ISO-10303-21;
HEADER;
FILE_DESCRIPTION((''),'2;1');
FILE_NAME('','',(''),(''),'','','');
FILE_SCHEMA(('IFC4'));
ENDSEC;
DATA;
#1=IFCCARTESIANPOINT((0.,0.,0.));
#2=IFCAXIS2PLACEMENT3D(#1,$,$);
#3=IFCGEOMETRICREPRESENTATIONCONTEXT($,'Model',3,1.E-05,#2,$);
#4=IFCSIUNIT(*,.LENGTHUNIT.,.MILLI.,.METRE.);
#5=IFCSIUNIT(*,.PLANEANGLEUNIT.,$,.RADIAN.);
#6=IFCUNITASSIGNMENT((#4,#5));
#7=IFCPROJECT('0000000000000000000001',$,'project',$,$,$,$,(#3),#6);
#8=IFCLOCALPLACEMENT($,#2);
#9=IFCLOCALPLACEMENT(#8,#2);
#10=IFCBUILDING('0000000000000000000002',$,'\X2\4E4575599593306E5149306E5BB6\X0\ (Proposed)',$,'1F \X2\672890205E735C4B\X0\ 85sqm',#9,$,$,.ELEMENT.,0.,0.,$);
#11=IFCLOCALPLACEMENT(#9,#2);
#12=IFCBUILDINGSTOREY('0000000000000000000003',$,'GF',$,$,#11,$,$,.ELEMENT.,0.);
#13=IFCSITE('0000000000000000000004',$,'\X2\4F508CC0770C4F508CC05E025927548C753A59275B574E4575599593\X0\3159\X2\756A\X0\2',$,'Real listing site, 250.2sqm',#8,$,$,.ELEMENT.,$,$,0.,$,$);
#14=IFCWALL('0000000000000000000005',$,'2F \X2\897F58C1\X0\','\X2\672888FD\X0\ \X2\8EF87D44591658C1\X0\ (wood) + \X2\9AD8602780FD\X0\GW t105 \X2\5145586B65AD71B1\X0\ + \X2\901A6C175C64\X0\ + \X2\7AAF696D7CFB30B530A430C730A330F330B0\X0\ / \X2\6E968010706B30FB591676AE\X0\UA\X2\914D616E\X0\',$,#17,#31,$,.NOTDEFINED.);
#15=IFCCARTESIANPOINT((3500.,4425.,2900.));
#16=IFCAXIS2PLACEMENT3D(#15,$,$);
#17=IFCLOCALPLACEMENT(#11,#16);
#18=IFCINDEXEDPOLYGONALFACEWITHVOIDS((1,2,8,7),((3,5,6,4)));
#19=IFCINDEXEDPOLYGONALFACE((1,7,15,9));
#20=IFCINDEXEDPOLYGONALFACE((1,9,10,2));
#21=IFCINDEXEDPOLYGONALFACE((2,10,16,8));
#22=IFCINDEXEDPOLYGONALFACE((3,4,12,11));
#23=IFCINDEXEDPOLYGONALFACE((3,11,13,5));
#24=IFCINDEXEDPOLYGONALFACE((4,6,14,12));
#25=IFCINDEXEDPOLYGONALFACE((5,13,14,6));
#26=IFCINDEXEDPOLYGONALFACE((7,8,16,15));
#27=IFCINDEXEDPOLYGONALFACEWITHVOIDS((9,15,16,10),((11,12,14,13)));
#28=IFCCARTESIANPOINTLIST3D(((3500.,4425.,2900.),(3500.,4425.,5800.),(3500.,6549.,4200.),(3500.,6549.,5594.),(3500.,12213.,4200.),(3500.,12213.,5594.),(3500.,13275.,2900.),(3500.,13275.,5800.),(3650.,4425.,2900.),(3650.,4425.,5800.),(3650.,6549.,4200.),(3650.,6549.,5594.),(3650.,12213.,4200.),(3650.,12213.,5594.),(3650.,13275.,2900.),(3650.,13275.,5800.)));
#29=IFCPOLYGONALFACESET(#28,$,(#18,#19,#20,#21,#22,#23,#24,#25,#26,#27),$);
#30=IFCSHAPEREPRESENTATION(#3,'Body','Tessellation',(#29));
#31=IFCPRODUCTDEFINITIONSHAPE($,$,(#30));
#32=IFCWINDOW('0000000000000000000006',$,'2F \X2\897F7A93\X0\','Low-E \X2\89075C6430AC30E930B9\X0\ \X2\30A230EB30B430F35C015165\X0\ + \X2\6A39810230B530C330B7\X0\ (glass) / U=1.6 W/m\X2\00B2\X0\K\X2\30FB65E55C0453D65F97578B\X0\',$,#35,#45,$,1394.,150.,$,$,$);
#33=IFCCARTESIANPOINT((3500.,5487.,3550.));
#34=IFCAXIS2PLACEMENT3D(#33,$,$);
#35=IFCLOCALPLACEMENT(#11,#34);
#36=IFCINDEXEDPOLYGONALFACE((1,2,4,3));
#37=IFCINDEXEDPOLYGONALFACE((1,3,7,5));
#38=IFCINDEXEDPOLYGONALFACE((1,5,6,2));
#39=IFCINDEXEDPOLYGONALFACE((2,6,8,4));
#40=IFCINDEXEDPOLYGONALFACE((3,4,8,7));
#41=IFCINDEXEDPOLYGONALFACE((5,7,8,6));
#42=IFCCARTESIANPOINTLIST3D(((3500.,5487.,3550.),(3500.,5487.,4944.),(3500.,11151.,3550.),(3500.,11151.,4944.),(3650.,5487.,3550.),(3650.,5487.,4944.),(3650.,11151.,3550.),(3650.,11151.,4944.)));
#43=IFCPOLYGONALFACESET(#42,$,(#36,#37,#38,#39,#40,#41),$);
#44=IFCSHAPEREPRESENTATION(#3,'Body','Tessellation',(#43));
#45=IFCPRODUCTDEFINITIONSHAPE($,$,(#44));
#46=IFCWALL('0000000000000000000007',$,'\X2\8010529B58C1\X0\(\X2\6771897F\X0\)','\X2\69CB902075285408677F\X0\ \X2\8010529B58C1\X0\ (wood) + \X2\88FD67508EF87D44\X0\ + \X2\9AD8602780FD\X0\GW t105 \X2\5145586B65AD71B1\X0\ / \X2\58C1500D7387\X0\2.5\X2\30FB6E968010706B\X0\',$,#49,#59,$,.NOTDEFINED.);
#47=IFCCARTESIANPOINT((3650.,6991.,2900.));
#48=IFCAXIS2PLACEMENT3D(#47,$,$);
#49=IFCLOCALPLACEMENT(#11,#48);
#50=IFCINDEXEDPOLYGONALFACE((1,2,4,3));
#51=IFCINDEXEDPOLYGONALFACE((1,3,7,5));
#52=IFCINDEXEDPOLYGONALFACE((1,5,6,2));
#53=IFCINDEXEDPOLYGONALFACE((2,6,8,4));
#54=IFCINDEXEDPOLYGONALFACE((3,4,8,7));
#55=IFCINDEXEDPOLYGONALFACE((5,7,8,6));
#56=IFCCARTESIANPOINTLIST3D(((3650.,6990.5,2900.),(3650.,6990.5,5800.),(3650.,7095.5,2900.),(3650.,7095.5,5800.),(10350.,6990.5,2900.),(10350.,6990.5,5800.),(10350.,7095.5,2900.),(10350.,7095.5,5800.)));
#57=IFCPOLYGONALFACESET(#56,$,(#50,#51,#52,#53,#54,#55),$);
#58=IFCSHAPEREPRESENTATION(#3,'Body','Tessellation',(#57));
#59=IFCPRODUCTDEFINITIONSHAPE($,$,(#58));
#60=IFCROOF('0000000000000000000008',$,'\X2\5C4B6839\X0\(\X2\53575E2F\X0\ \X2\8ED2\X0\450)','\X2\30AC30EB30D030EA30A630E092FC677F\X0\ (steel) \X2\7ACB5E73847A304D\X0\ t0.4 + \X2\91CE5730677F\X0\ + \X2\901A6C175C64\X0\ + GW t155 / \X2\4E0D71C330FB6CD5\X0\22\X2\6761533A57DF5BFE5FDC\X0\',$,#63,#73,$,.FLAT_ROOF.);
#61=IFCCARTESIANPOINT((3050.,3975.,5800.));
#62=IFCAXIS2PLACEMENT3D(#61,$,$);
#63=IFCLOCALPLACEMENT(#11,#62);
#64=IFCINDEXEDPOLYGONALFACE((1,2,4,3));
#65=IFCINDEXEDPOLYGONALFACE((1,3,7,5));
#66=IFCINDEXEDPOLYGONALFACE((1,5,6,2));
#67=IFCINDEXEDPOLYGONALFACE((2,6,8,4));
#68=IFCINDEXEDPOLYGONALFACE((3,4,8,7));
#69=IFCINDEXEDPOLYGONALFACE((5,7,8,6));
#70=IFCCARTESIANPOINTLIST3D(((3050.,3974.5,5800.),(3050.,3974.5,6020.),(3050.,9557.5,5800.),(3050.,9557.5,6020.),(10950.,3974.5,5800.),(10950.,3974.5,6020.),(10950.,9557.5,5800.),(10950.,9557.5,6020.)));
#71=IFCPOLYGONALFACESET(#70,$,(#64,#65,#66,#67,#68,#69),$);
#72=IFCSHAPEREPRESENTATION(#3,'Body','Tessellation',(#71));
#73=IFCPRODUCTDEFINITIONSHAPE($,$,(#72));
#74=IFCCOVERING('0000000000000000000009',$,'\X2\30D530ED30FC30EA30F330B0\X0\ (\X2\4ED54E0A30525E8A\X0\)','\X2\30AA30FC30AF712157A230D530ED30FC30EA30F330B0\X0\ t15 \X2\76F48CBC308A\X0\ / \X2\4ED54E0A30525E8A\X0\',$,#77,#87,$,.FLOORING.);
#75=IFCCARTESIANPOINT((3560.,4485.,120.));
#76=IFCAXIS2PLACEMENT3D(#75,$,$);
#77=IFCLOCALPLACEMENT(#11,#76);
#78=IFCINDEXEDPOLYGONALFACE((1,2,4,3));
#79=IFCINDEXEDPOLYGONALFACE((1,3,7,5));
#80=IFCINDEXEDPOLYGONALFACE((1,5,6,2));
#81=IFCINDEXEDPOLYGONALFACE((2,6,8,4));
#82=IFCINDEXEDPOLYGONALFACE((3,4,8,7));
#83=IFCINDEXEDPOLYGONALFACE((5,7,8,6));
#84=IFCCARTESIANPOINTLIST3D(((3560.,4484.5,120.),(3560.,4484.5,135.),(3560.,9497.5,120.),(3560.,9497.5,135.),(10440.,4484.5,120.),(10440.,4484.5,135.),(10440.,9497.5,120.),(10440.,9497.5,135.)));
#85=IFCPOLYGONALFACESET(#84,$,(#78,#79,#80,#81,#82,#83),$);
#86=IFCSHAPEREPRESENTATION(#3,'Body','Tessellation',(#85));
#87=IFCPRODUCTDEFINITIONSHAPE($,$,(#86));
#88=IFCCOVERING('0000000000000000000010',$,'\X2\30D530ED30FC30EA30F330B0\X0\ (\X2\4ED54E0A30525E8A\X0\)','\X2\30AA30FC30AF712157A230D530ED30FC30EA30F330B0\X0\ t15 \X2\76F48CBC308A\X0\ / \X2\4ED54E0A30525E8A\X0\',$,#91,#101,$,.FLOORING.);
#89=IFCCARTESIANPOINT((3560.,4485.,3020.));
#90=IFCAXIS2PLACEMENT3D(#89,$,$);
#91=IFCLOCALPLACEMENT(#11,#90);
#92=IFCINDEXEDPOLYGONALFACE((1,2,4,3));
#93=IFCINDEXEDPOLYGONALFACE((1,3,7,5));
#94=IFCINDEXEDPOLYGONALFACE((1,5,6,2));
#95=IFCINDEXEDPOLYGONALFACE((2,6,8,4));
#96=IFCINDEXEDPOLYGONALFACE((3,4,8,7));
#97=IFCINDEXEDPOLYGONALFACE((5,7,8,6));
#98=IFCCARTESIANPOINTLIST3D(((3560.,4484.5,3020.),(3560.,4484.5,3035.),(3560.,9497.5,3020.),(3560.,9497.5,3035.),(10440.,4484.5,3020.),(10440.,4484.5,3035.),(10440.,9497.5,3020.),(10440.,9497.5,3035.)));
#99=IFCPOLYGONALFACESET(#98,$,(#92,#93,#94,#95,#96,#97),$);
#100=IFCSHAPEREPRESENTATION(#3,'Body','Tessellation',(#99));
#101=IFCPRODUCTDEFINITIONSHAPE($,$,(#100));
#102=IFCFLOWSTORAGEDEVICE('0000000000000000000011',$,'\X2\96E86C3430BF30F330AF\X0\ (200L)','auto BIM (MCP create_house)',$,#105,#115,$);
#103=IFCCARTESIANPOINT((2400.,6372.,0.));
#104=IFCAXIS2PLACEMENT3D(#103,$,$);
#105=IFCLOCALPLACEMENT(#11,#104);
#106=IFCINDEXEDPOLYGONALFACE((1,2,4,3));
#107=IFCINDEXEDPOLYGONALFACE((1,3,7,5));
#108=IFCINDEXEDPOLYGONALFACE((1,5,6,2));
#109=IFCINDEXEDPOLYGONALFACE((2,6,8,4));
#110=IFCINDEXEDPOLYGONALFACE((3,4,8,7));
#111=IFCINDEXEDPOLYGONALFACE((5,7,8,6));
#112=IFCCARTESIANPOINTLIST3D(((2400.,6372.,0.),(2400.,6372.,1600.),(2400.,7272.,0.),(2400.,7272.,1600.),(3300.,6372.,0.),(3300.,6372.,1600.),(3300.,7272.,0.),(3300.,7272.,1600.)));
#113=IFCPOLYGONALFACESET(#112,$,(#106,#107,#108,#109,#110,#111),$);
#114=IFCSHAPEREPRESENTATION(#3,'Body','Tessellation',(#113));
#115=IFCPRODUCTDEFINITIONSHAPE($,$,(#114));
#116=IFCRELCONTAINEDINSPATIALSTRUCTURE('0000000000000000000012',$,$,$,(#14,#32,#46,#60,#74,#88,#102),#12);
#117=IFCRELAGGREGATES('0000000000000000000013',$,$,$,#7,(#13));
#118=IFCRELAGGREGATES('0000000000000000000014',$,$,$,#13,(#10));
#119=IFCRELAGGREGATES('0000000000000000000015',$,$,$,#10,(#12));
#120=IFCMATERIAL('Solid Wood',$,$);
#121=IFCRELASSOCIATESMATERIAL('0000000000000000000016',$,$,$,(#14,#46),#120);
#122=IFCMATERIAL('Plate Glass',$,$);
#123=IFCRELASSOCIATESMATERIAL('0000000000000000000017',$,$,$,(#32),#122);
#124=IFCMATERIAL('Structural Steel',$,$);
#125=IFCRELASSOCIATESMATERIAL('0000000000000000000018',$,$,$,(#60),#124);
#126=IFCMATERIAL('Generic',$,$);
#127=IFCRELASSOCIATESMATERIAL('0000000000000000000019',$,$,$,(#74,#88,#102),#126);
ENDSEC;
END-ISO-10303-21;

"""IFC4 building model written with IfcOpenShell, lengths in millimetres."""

from ifc_helpers import new_model, si_unit, frame, frame_2d, origin, place, context, project, spatial, rectangle, extrude, material, element, fill, save


model = new_model("IFC4")

# Units and contexts
model_context = context("Model", 3, precision=1e-05, world=origin())
ifc_project = project(units=[si_unit("LENGTHUNIT", "METRE", prefix="MILLI"), si_unit("PLANEANGLEUNIT", "RADIAN")], contexts=[model_context])

# Site, building, storey
site_placement = place(None, origin())
site = spatial("IfcSite", under=ifc_project, at=site_placement, Name="佐賀県佐賀市大和町大字久留間3159番2", ObjectType="Real listing site, 250.2sqm", CompositionType="ELEMENT", RefElevation=0.0)
building_placement = place(site_placement, origin())
building = spatial("IfcBuilding", under=site, at=building_placement, Name="久留間の光の家 (Proposed)", ObjectType="1F 木造平屋 85sqm", CompositionType="ELEMENT", ElevationOfRefHeight=0.0, ElevationOfTerrain=0.0)
storey_placement = place(building_placement, origin())
storey = spatial("IfcBuildingStorey", under=building, at=storey_placement, Name="GF", CompositionType="ELEMENT", Elevation=0.0)

# Shared definitions
ifc_material_1 = material(Name="Solid Wood")
ifc_material_2 = material(Name="Generic")

# Shared definitions
ifc_material_3 = material(Name="Plate Glass")

# Wall, opening, window
wall_1_placement = place(storey_placement, frame((3500.0, 4425.0, 2900.0)))
wall_1 = element("IfcWall", 1, at=wall_1_placement, inside=storey, material=ifc_material_1, Name="2F 西壁", Description="木製 軸組外壁 (wood) + 高性能GW t105 充填断熱 + 通気層 + 窯業系サイディング / 準耐火・外皮UA配慮", PredefinedType="NOTDEFINED", context=model_context, shape_type="SweptSolid", body=[
    extrude(rectangle(XDim=150.0, YDim=8850.0, at=frame_2d((75.0, 4425.0))), frame((3500.0, 4425.0, 2900.0)), (0.0, 0.0, 1.0), 2900.0),
])
opening_1_placement = place(storey_placement, frame((3500.0, 5487.0, 3550.0)))
opening_1 = element("IfcOpeningElement", 2, at=opening_1_placement, cuts=wall_1, PredefinedType="NOTDEFINED", context=model_context, shape_type="SweptSolid", body=[
    extrude(rectangle(XDim=150.0, YDim=5664.0, at=frame_2d((75.0, 2832.0))), frame((3500.0, 5487.0, 3550.0)), (0.0, 0.0, 1.0), 1394.0),
])
window_1_placement = place(storey_placement, frame((3500.0, 5487.0, 3550.0)))
window_1 = element("IfcWindow", 3, at=window_1_placement, inside=storey, material=ifc_material_3, Name="2F 西窓", Description="Low-E 複層ガラス アルゴン封入 + 樹脂サッシ (glass) / U=1.6 W/m²K・日射取得型", OverallHeight=1394.0, OverallWidth=150.0, context=model_context, shape_type="SweptSolid", body=[
    extrude(rectangle(XDim=150.0, YDim=5664.0, at=frame_2d((75.0, 2832.0))), frame((3500.0, 5487.0, 3550.0)), (0.0, 0.0, 1.0), 1394.0),
])
fill(opening_1, window_1)

# Wall
wall_2_placement = place(storey_placement, frame((3650.0, 6991.0, 2900.0)))
element("IfcWall", 4, at=wall_2_placement, inside=storey, material=ifc_material_1, Name="耐力壁(東西)", Description="構造用合板 耐力壁 (wood) + 製材軸組 + 高性能GW t105 充填断熱 / 壁倍率2.5・準耐火", PredefinedType="NOTDEFINED", context=model_context, shape_type="SweptSolid", body=[
    extrude(rectangle(XDim=6700.0, YDim=105.0, at=frame_2d((3350.0, 52.0))), frame((3650.0, 6991.0, 2900.0)), (0.0, 0.0, 1.0), 2900.0),
])

# Roof
ifc_material_4 = material(Name="Structural Steel")
for number, where, name in (
    (5, (3050.0, 3975.0, 5800.0), "屋根(南帯 軒450)"),
):
    element("IfcRoof", number, at=place(storey_placement, frame(where)), inside=storey, material=ifc_material_4, Name=name, Description="ガルバリウム鋼板 (steel) 立平葺き t0.4 + 野地板 + 通気層 + GW t155 / 不燃・法22条区域対応", PredefinedType="FLAT_ROOF", context=model_context, shape_type="SweptSolid", body=[
        extrude(rectangle(XDim=7900.0, YDim=5583.0, at=frame_2d((3950.0, 2791.0))), frame((3050.0, 3975.0, 5800.0)), (0.0, 0.0, 1.0), 220.0),
    ])

# Coverings
covering_1_placement = place(storey_placement, frame((3560.0, 4485.0, 120.0)))
element("IfcCovering", 6, at=covering_1_placement, inside=storey, material=ifc_material_2, Name="フローリング (仕上げ床)", Description="オーク無垢フローリング t15 直貼り / 仕上げ床", PredefinedType="FLOORING", context=model_context, shape_type="SweptSolid", body=[
    extrude(rectangle(XDim=6880.0, YDim=5013.0, at=frame_2d((3440.0, 2506.0))), frame((3560.0, 4485.0, 120.0)), (0.0, 0.0, 1.0), 15.0),
])
covering_2_placement = place(storey_placement, frame((3560.0, 4485.0, 3020.0)))
element("IfcCovering", 7, at=covering_2_placement, inside=storey, material=ifc_material_2, Name="フローリング (仕上げ床)", Description="オーク無垢フローリング t15 直貼り / 仕上げ床", PredefinedType="FLOORING", context=model_context, shape_type="SweptSolid", body=[
    extrude(rectangle(XDim=6880.0, YDim=5013.0, at=frame_2d((3440.0, 2506.0))), frame((3560.0, 4485.0, 3020.0)), (0.0, 0.0, 1.0), 15.0),
])

# Flow storage device
flow_storage_device_placement = place(storey_placement, frame((2400.0, 6372.0, 0.0)))
element("IfcFlowStorageDevice", 8, at=flow_storage_device_placement, inside=storey, material=ifc_material_2, Name="雨水タンク (200L)", Description="auto BIM (MCP create_house)", context=model_context, shape_type="SweptSolid", body=[
    extrude(rectangle(XDim=900.0, YDim=900.0, at=frame_2d((450.0, 450.0))), frame((2400.0, 6372.0, 0.0)), (0.0, 0.0, 1.0), 1600.0),
])

save(model, "model.ifc")
